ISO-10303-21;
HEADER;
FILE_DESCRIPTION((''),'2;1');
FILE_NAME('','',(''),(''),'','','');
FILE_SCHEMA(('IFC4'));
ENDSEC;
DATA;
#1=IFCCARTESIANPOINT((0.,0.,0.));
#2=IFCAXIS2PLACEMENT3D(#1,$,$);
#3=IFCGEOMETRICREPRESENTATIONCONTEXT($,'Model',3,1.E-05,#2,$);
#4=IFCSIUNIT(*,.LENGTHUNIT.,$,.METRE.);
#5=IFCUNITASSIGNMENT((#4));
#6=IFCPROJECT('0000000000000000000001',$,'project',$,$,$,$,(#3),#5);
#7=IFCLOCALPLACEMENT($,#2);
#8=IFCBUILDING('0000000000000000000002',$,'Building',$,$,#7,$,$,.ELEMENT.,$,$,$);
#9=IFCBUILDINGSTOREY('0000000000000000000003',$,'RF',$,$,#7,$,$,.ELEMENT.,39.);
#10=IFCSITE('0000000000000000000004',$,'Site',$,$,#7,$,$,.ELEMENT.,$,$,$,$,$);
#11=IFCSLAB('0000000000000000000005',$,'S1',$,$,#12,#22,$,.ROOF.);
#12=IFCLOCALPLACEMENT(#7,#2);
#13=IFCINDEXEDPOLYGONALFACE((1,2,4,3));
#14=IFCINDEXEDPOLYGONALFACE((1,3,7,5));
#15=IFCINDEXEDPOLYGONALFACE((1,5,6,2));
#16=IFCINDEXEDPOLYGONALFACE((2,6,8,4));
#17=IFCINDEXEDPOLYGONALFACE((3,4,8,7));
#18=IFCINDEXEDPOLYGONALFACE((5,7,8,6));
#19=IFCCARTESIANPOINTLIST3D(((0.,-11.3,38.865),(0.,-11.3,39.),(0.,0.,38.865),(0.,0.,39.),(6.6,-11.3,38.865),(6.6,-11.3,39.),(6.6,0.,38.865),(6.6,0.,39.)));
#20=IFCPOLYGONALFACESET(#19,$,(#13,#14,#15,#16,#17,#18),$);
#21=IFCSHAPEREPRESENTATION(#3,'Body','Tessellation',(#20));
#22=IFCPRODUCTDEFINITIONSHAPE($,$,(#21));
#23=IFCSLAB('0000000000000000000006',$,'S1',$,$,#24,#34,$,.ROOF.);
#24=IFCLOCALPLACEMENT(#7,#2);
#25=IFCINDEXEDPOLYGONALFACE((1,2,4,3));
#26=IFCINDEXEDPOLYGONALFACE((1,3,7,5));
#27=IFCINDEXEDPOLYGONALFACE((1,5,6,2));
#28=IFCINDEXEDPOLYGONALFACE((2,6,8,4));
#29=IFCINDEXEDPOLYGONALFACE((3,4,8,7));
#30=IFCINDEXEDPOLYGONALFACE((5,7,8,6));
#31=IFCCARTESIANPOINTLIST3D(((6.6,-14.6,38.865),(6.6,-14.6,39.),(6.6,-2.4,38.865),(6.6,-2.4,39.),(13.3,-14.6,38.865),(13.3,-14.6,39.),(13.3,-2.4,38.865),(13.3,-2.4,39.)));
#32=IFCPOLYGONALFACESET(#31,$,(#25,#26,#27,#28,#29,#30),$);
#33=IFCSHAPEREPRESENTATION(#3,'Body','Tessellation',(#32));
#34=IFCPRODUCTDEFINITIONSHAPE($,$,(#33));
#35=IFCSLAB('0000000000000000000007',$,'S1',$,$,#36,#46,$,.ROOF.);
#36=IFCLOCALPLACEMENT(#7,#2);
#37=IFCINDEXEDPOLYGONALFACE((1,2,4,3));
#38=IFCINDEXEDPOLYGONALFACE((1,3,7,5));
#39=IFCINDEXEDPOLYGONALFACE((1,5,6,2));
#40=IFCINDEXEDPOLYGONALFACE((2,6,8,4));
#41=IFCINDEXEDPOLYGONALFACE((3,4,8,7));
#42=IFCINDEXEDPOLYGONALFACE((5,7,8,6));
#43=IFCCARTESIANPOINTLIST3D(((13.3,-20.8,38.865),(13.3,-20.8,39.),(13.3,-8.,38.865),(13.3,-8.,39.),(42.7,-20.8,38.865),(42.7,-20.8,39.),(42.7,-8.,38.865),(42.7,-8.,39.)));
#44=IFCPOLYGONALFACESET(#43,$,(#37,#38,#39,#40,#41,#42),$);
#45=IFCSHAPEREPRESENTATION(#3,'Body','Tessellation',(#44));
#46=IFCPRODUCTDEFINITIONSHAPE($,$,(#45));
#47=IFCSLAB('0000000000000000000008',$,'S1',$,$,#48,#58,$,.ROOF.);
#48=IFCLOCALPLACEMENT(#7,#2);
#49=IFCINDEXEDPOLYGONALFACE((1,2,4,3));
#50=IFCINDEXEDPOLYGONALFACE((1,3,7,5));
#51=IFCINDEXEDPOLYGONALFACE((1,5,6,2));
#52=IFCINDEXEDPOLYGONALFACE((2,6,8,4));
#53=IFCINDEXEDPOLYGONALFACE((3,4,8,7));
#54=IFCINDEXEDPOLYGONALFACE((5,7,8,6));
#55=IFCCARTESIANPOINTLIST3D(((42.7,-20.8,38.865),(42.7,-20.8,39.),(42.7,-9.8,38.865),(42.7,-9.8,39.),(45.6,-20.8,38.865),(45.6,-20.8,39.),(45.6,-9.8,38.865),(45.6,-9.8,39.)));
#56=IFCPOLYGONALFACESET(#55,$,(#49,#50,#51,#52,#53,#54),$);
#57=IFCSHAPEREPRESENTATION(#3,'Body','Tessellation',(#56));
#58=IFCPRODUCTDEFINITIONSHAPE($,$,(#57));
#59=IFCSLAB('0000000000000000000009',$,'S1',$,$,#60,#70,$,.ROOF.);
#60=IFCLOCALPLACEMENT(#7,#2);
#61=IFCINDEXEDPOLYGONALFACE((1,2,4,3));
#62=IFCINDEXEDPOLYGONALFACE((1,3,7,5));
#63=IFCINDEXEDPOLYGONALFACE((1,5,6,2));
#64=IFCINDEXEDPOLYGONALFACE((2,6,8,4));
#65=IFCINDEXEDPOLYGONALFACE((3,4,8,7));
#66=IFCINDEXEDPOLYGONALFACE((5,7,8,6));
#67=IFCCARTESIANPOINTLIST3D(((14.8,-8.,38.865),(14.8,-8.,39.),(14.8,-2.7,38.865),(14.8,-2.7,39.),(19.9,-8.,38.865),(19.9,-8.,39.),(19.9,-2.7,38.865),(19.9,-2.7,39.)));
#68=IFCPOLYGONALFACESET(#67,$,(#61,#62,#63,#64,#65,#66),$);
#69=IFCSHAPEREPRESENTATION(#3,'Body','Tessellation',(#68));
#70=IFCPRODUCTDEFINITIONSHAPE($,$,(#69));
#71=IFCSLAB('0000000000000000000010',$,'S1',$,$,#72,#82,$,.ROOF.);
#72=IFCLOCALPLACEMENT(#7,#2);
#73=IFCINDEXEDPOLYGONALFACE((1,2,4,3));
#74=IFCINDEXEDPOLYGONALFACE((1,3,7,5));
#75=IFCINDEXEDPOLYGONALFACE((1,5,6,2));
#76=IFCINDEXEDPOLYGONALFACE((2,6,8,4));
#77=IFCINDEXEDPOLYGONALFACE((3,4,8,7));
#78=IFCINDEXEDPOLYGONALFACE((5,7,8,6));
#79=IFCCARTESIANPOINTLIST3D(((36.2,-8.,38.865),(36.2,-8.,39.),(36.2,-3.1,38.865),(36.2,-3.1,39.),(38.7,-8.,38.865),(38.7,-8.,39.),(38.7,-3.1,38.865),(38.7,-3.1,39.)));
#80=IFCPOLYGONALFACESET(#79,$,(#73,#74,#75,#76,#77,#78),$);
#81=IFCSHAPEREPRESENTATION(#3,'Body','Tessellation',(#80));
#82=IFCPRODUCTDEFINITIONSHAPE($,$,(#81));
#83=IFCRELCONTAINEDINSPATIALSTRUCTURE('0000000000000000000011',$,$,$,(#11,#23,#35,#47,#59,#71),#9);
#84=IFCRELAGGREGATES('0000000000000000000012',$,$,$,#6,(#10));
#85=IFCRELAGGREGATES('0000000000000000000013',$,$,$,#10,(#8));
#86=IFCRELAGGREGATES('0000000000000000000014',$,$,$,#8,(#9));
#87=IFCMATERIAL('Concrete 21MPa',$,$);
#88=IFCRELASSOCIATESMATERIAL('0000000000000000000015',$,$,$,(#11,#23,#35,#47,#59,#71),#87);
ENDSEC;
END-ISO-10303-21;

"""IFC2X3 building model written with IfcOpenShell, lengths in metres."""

from ifc_helpers import new_model, si_unit, frame, origin, origin_2d, place, context, project, spatial, rectangle, extrude, material, element, save


model = new_model("IFC2X3")

# Units and contexts
model_context = context("Model", 3, precision=1e-05, world=origin())
ifc_project = project(units=[si_unit("LENGTHUNIT", "METRE")], contexts=[model_context])

# Site, building, storey
placement = place(None, origin())
site = spatial("IfcSite", under=ifc_project, at=placement, Name="Site", CompositionType="ELEMENT")
building = spatial("IfcBuilding", under=site, at=placement, Name="Building", CompositionType="ELEMENT")
storey = spatial("IfcBuildingStorey", under=building, at=placement, Name="RF", CompositionType="ELEMENT", Elevation=39.0)

# Slabs
ifc_material = material(Name="Concrete 21MPa")
slab_1_placement = place(None, frame((3.3, -5.65, 38.865)))
element("IfcSlab", 1, at=slab_1_placement, inside=storey, material=ifc_material, Name="S1", PredefinedType="ROOF", context=model_context, shape_type="SweptSolid", body=[
    extrude(rectangle(XDim=6.6, YDim=11.3, at=origin_2d()), origin(), (0.0, 0.0, 1.0), 0.135),
])
slab_2_placement = place(None, frame((9.95, -8.5, 38.865)))
element("IfcSlab", 2, at=slab_2_placement, inside=storey, material=ifc_material, Name="S1", PredefinedType="ROOF", context=model_context, shape_type="SweptSolid", body=[
    extrude(rectangle(XDim=6.7, YDim=12.2, at=origin_2d()), origin(), (0.0, 0.0, 1.0), 0.135),
])
slab_3_placement = place(None, frame((28.0, -14.4, 38.865)))
element("IfcSlab", 3, at=slab_3_placement, inside=storey, material=ifc_material, Name="S1", PredefinedType="ROOF", context=model_context, shape_type="SweptSolid", body=[
    extrude(rectangle(XDim=29.4, YDim=12.8, at=origin_2d()), origin(), (0.0, 0.0, 1.0), 0.135),
])
slab_4_placement = place(None, frame((44.15, -15.3, 38.865)))
element("IfcSlab", 4, at=slab_4_placement, inside=storey, material=ifc_material, Name="S1", PredefinedType="ROOF", context=model_context, shape_type="SweptSolid", body=[
    extrude(rectangle(XDim=2.9, YDim=11.0, at=origin_2d()), origin(), (0.0, 0.0, 1.0), 0.135),
])
slab_5_placement = place(None, frame((17.35, -5.35, 38.865)))
element("IfcSlab", 5, at=slab_5_placement, inside=storey, material=ifc_material, Name="S1", PredefinedType="ROOF", context=model_context, shape_type="SweptSolid", body=[
    extrude(rectangle(XDim=5.1, YDim=5.3, at=origin_2d()), origin(), (0.0, 0.0, 1.0), 0.135),
])
slab_6_placement = place(None, frame((37.45, -5.55, 38.865)))
element("IfcSlab", 6, at=slab_6_placement, inside=storey, material=ifc_material, Name="S1", PredefinedType="ROOF", context=model_context, shape_type="SweptSolid", body=[
    extrude(rectangle(XDim=2.5, YDim=4.9, at=origin_2d()), origin(), (0.0, 0.0, 1.0), 0.135),
])

save(model, "model.ifc")
